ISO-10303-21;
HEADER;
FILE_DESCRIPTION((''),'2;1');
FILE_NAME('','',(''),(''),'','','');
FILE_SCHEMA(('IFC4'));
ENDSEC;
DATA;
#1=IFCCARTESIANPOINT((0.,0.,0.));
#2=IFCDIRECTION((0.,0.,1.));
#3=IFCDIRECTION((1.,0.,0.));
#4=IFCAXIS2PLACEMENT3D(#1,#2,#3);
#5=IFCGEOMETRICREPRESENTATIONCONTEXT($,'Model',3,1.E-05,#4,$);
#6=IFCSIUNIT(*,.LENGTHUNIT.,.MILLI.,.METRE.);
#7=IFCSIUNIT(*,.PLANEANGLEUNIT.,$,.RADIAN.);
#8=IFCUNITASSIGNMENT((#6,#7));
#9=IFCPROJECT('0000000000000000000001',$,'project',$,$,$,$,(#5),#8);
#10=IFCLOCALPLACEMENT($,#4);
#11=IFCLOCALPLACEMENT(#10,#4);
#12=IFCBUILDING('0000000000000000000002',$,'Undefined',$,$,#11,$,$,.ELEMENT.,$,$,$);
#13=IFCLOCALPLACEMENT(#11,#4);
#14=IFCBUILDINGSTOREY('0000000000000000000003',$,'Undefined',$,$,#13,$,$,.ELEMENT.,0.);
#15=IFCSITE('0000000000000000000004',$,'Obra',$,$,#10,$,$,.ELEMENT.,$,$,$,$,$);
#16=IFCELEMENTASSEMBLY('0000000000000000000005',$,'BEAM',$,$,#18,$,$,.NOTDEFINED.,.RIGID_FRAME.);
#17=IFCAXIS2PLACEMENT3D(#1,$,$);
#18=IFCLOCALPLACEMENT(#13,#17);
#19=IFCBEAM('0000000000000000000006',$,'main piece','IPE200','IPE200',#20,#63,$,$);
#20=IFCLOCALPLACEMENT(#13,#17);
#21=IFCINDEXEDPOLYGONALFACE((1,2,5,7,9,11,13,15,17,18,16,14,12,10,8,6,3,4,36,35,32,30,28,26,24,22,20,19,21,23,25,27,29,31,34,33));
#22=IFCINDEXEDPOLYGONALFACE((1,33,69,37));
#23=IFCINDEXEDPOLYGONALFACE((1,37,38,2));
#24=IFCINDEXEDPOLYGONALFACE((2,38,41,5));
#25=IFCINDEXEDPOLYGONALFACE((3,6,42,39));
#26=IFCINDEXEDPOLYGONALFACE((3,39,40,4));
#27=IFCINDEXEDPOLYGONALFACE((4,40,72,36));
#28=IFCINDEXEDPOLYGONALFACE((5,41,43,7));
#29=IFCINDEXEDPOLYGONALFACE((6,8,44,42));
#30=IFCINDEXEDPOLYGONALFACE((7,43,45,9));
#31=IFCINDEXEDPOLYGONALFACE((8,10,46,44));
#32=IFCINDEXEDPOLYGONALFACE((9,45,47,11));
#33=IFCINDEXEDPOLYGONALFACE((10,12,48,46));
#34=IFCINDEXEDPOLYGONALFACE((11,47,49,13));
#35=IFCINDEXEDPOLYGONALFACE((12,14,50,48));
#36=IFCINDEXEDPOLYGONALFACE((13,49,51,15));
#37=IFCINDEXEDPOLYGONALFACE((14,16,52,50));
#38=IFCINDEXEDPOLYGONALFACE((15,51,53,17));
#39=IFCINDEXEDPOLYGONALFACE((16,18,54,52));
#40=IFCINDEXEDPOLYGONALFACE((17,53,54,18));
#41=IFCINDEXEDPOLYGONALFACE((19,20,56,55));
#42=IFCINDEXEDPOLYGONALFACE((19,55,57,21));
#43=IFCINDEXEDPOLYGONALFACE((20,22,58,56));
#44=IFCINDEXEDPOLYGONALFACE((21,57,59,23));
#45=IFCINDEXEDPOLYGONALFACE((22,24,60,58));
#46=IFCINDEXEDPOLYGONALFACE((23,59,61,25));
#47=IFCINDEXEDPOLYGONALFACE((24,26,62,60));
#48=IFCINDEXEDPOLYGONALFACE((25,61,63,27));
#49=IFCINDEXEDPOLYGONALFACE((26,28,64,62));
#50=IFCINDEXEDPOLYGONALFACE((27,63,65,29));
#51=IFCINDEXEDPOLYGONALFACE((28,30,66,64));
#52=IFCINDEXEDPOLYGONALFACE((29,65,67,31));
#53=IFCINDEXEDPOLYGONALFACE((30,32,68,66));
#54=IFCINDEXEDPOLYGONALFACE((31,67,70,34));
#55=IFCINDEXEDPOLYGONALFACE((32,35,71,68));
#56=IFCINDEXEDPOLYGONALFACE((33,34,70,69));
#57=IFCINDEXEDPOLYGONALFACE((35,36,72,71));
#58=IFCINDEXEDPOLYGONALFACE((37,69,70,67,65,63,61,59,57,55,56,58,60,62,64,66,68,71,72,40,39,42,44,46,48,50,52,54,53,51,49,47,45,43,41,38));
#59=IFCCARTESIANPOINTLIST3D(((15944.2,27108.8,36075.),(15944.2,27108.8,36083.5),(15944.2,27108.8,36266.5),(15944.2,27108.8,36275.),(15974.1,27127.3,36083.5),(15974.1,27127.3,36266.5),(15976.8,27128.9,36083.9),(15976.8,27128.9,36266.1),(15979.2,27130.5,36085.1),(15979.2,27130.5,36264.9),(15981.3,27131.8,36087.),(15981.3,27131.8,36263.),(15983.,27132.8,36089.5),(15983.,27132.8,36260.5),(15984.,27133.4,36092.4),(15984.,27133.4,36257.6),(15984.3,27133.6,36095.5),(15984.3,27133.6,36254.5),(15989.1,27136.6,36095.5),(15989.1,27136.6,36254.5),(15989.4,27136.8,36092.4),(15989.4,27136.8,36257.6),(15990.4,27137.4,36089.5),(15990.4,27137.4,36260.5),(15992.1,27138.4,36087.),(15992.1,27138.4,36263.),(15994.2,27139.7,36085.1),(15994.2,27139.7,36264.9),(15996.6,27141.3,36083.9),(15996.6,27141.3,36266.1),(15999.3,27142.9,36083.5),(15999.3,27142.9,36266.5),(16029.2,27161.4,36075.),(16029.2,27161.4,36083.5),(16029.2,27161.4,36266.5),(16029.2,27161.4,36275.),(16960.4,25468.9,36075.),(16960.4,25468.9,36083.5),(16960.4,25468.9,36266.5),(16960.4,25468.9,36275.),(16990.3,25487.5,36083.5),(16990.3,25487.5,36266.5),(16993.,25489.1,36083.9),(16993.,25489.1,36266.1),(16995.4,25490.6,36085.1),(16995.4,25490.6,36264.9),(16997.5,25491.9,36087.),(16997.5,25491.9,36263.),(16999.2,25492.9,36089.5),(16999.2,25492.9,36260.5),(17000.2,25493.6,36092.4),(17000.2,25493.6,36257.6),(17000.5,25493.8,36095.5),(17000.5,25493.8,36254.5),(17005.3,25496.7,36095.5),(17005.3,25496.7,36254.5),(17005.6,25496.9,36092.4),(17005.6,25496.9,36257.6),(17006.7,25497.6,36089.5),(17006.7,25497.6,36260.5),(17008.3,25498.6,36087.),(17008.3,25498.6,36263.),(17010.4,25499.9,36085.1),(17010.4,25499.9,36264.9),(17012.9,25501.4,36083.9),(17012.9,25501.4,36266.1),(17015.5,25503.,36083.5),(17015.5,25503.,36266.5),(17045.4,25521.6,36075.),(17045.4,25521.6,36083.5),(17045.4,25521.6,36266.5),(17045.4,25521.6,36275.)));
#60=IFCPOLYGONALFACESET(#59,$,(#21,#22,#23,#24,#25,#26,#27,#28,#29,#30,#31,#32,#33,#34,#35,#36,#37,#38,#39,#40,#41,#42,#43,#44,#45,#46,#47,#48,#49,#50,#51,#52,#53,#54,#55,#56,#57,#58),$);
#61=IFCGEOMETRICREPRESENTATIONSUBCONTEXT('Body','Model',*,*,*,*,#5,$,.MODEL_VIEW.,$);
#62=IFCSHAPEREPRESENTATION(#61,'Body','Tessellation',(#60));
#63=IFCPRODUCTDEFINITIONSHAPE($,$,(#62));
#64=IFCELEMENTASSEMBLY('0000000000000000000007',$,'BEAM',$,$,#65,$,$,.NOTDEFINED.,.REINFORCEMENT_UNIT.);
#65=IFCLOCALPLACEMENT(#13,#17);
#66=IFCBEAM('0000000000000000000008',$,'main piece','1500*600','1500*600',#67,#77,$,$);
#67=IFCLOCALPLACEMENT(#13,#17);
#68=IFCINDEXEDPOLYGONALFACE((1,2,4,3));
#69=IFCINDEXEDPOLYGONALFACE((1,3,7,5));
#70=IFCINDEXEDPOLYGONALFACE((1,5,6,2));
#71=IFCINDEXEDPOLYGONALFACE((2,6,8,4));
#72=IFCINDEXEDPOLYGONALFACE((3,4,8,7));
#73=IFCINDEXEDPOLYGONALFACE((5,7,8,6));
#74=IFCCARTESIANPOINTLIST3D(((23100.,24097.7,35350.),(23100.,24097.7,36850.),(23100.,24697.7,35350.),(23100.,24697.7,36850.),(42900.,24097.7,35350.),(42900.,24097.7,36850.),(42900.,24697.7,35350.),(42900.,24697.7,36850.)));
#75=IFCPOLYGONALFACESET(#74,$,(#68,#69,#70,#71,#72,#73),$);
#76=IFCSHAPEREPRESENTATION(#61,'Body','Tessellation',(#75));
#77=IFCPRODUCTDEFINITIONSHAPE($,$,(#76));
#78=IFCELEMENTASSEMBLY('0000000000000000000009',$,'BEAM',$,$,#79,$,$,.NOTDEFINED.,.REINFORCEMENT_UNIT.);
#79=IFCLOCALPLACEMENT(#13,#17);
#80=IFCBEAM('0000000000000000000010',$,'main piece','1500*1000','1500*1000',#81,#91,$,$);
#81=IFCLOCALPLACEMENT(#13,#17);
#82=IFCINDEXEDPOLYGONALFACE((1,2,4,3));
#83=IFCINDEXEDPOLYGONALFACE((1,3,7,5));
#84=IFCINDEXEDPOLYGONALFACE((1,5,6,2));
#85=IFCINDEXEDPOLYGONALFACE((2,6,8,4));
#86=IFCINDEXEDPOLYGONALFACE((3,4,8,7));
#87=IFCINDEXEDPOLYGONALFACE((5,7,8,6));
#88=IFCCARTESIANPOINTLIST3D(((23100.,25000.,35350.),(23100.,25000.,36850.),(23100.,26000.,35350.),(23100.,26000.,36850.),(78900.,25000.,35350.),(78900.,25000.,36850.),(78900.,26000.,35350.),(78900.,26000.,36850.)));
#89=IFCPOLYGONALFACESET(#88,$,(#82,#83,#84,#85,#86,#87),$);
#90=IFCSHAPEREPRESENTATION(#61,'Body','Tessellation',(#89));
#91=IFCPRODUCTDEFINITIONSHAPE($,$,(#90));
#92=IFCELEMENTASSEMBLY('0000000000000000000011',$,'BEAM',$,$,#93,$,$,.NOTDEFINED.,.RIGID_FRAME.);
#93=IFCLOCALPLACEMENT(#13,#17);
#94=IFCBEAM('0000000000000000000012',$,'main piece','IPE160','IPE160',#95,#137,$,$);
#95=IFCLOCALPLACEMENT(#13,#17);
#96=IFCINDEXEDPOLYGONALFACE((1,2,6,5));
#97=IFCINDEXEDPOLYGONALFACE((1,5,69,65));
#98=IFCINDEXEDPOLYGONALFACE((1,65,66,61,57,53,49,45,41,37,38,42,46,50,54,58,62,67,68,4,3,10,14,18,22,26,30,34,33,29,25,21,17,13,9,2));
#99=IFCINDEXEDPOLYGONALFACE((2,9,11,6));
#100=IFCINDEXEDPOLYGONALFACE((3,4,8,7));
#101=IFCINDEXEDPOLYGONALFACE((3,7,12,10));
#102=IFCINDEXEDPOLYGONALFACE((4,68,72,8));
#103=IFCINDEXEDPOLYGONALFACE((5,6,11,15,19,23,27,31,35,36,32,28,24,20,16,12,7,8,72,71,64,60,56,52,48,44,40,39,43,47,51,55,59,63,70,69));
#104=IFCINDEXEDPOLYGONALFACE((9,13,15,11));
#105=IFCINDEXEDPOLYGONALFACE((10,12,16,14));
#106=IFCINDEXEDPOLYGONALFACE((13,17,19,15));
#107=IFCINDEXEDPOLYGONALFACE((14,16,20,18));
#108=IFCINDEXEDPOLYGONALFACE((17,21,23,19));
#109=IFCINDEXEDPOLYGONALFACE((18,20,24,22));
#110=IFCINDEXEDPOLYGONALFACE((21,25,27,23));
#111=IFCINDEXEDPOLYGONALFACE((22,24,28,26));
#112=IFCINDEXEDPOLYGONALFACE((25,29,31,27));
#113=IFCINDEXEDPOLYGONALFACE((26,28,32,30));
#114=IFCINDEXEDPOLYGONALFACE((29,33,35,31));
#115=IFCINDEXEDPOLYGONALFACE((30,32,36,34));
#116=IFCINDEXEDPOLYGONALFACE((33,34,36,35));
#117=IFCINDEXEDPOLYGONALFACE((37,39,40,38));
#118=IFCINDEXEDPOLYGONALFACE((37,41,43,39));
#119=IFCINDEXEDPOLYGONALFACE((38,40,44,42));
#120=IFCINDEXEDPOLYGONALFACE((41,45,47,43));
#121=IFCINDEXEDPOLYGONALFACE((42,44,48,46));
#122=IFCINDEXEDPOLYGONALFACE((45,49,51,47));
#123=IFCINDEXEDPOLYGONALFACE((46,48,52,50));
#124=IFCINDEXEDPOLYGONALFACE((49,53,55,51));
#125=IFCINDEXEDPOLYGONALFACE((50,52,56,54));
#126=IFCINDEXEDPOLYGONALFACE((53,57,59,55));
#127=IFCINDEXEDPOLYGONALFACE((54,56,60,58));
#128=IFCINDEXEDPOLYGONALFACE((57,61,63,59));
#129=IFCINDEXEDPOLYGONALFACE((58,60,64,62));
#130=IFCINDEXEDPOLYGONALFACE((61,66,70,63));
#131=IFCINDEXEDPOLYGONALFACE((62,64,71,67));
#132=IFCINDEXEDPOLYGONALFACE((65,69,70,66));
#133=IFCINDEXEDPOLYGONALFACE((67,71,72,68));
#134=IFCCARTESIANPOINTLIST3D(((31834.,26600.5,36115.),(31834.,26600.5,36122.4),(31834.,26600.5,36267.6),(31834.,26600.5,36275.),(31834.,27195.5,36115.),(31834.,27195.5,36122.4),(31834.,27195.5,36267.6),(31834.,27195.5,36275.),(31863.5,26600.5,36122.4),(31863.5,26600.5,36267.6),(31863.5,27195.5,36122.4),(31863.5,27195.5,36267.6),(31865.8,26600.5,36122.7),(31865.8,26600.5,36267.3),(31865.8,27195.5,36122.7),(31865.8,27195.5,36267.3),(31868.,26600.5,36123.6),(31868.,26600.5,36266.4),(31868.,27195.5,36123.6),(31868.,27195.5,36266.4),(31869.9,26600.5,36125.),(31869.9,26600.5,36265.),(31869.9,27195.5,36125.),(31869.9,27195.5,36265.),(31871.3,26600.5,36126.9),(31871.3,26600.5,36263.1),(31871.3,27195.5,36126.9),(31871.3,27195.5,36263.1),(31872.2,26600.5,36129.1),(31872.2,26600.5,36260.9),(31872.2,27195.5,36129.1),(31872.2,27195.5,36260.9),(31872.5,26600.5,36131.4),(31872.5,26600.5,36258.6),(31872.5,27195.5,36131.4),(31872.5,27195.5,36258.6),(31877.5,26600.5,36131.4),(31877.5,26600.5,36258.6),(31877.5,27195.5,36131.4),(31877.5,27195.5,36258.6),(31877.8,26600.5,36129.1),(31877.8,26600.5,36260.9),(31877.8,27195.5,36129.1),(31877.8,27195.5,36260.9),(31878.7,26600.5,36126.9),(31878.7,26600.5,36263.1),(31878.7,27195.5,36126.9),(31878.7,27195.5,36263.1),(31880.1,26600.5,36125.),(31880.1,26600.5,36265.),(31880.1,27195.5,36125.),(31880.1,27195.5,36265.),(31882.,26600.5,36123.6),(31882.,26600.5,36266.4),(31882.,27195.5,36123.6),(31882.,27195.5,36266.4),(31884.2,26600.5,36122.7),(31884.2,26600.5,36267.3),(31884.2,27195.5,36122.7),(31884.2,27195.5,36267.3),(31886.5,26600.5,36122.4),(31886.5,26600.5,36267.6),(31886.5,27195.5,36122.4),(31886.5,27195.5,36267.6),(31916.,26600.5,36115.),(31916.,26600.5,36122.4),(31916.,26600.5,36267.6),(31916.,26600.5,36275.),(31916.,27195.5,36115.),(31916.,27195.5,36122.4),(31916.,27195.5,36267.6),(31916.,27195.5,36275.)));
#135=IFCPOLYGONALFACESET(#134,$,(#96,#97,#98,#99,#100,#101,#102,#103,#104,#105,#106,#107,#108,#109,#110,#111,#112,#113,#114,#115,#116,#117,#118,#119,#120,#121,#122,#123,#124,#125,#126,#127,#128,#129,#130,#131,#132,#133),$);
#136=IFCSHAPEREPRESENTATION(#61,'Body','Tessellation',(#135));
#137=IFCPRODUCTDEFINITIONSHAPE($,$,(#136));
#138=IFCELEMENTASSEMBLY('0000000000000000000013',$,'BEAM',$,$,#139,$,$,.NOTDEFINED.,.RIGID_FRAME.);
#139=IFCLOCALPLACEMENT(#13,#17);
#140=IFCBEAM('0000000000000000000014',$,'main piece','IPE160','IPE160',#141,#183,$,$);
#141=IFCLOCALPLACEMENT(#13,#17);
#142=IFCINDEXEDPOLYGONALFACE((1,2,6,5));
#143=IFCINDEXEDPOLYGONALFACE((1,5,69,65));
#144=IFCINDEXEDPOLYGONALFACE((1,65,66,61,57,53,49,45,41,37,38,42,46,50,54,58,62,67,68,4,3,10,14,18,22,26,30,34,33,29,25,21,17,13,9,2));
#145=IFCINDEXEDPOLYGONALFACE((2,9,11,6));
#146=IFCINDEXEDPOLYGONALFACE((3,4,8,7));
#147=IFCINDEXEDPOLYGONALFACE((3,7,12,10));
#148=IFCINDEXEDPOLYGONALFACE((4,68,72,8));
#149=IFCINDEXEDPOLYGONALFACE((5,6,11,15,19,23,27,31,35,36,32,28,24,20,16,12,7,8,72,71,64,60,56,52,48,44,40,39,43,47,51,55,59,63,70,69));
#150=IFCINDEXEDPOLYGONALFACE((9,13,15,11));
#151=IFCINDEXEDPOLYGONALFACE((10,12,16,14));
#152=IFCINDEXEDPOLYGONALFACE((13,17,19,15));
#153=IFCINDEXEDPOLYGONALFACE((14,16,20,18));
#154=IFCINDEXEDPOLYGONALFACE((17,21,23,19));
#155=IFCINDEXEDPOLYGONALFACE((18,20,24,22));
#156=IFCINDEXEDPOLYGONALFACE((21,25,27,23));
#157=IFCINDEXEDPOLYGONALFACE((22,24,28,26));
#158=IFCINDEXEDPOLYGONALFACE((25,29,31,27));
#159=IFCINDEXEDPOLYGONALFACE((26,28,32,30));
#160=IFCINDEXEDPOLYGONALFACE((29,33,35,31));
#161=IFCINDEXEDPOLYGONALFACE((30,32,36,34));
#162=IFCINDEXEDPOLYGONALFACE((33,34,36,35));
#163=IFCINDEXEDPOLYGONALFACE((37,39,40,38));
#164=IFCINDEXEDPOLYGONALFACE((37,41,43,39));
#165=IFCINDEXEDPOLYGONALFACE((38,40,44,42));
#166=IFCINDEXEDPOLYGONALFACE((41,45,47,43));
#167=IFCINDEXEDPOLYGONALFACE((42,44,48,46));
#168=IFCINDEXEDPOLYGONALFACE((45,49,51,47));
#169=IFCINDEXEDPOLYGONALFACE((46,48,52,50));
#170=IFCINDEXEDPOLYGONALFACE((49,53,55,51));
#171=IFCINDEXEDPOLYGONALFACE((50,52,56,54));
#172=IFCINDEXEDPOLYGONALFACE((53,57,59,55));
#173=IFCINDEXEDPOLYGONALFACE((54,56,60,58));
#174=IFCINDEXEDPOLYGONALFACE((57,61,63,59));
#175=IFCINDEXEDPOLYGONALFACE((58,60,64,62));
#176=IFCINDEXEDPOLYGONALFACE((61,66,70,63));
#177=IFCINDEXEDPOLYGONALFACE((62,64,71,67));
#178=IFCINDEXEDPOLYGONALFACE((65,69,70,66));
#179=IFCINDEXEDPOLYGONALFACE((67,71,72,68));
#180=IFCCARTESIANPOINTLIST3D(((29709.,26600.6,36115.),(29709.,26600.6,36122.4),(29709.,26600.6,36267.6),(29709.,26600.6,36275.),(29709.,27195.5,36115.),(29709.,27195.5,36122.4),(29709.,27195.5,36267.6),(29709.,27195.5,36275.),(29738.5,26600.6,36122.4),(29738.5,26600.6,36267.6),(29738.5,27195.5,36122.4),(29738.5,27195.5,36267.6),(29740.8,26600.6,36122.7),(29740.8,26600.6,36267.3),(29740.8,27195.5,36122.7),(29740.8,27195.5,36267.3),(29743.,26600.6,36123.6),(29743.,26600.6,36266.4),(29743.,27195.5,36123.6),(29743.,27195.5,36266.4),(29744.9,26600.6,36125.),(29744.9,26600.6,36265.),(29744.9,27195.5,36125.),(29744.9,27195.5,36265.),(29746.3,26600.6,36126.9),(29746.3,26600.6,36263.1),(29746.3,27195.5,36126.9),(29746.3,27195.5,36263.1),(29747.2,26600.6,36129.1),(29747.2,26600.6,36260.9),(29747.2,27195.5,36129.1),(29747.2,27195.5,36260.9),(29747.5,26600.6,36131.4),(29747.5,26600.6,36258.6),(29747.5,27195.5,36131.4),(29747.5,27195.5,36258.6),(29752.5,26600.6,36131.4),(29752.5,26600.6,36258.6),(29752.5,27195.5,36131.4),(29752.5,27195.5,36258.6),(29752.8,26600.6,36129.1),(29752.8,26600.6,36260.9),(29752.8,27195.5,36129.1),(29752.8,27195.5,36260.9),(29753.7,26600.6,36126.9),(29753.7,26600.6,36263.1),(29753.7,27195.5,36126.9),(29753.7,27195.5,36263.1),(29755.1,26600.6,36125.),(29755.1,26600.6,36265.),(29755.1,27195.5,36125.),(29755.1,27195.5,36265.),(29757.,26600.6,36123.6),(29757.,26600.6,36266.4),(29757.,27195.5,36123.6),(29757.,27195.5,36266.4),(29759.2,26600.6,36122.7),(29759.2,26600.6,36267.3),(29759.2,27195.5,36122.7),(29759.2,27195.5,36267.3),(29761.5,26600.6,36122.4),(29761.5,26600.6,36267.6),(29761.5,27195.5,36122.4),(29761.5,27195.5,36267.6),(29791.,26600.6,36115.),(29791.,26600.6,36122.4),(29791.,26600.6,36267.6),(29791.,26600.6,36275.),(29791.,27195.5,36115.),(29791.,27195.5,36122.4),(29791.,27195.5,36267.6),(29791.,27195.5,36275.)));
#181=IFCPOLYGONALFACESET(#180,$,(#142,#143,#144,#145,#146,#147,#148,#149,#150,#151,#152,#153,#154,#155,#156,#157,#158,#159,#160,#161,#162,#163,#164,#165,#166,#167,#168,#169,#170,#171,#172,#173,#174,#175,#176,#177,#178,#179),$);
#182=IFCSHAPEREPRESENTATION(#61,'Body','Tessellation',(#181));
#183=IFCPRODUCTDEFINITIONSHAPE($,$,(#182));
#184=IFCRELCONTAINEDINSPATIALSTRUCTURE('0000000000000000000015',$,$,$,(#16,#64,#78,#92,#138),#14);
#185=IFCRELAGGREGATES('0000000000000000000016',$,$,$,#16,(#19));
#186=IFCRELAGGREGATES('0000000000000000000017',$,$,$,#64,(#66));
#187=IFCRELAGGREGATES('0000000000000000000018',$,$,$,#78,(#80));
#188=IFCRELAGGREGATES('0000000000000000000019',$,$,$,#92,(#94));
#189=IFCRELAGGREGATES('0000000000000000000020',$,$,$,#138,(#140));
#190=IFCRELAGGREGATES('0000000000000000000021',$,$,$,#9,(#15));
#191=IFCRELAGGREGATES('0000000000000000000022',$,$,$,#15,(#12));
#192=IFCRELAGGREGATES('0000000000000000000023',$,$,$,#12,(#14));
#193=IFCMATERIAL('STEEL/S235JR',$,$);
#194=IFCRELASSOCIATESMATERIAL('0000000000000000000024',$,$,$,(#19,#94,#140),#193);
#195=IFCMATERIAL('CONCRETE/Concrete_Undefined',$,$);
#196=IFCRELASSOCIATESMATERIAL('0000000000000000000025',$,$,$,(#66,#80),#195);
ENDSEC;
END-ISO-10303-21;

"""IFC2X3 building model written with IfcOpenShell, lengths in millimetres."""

from ifc_helpers import new_model, si_unit, frame, origin_with_axes, origin_2d_with_axis, place, context, subcontext, project, spatial, rectangle, i_section, extrude, material, element, aggregate, save


model = new_model("IFC2X3")

# Units and contexts
model_context = context("Model", 3, precision=1e-05, world=origin_with_axes())
body_context = subcontext(model_context, "Body", "Model", "MODEL_VIEW")
ifc_project = project(units=[si_unit("LENGTHUNIT", "METRE", prefix="MILLI"), si_unit("PLANEANGLEUNIT", "RADIAN")], contexts=[model_context])

# Site, building, storey
site_placement = place(None, origin_with_axes())
site = spatial("IfcSite", under=ifc_project, at=site_placement, Name="Obra", CompositionType="ELEMENT")
building_placement = place(site_placement, origin_with_axes())
building = spatial("IfcBuilding", under=site, at=building_placement, Name="Undefined", CompositionType="ELEMENT")
storey_placement = place(building_placement, origin_with_axes())
storey = spatial("IfcBuildingStorey", under=building, at=storey_placement, Name="Undefined", CompositionType="ELEMENT", Elevation=0.0)

# Shared definitions
ifc_material_1 = material(Name="STEEL/S235JR")

# Element assemblies, beams
ifc_material_2 = material(Name="CONCRETE/Concrete_Undefined")
assembly_1_placement = place(storey_placement, origin_with_axes())
assembly_1 = element("IfcElementAssembly", 1, at=assembly_1_placement, inside=storey, Name="BEAM", AssemblyPlace="NOTDEFINED", PredefinedType="RIGID_FRAME")
beam_1_placement = place(assembly_1_placement, frame((17002.9, 25495.3, 36175.0), z_axis=(0.0, 0.0, 1.0), x_axis=(-0.526756, 0.850017, 0.0)))
beam_1 = element("IfcBeam", 2, at=beam_1_placement, material=ifc_material_1, Name="main piece", Description="IPE200", ObjectType="IPE200", context=body_context, shape_type="SweptSolid", body=[
    extrude(i_section(OverallWidth=100.0, OverallDepth=200.0, WebThickness=5.6, FlangeThickness=8.5, FilletRadius=12.0, at=origin_2d_with_axis()), frame((1929.2, 0.0, 0.0), z_axis=(-1.0, 0.0, 0.0), x_axis=(0.0, -1.0, 0.0)), (0.0, 0.0, 1.0), 1929.2),
])
aggregate(assembly_1, [beam_1])
assembly_2_placement = place(storey_placement, origin_with_axes())
assembly_2 = element("IfcElementAssembly", 3, at=assembly_2_placement, inside=storey, Name="BEAM", AssemblyPlace="NOTDEFINED", PredefinedType="REINFORCEMENT_UNIT")
beam_2_placement = place(assembly_2_placement, frame((23100.0, 24397.7, 36100.0), z_axis=(0.0, 0.0, 1.0), x_axis=(1.0, 0.0, 0.0)))
beam_2 = element("IfcBeam", 4, at=beam_2_placement, material=ifc_material_2, Name="main piece", Description="1500*600", ObjectType="1500*600", context=body_context, shape_type="SweptSolid", body=[
    extrude(rectangle(XDim=600.0, YDim=1500.0, at=origin_2d_with_axis()), frame((19800.0, 0.0, 0.0), z_axis=(-1.0, 0.0, 0.0), x_axis=(0.0, -1.0, 0.0)), (0.0, 0.0, 1.0), 19800.0),
])
aggregate(assembly_2, [beam_2])
assembly_3_placement = place(storey_placement, origin_with_axes())
assembly_3 = element("IfcElementAssembly", 5, at=assembly_3_placement, inside=storey, Name="BEAM", AssemblyPlace="NOTDEFINED", PredefinedType="REINFORCEMENT_UNIT")
beam_3_placement = place(assembly_3_placement, frame((23100.0, 25500.0, 36100.0), z_axis=(0.0, 0.0, 1.0), x_axis=(1.0, 0.0, 0.0)))
beam_3 = element("IfcBeam", 6, at=beam_3_placement, material=ifc_material_2, Name="main piece", Description="1500*1000", ObjectType="1500*1000", context=body_context, shape_type="SweptSolid", body=[
    extrude(rectangle(XDim=1000.0, YDim=1500.0, at=origin_2d_with_axis()), frame((55800.0, 0.0, 0.0), z_axis=(-1.0, 0.0, 0.0), x_axis=(0.0, -1.0, 0.0)), (0.0, 0.0, 1.0), 55800.0),
])
aggregate(assembly_3, [beam_3])
assembly_4_placement = place(storey_placement, origin_with_axes())
assembly_4 = element("IfcElementAssembly", 7, at=assembly_4_placement, inside=storey, Name="BEAM", AssemblyPlace="NOTDEFINED", PredefinedType="RIGID_FRAME")
beam_4_placement = place(assembly_4_placement, frame((31875.0, 26600.5, 36195.0), z_axis=(0.0, 0.0, 1.0), x_axis=(0.0, 1.0, 0.0)))
beam_4 = element("IfcBeam", 8, at=beam_4_placement, material=ifc_material_1, Name="main piece", Description="IPE160", ObjectType="IPE160", context=body_context, shape_type="SweptSolid", body=[
    extrude(i_section(OverallWidth=82.0, OverallDepth=160.0, WebThickness=5.0, FlangeThickness=7.4, FilletRadius=9.0, at=origin_2d_with_axis()), frame((595.0, 0.0, 0.0), z_axis=(-1.0, 0.0, 0.0), x_axis=(0.0, -1.0, 0.0)), (0.0, 0.0, 1.0), 595.0),
])
aggregate(assembly_4, [beam_4])
assembly_5_placement = place(storey_placement, origin_with_axes())
assembly_5 = element("IfcElementAssembly", 9, at=assembly_5_placement, inside=storey, Name="BEAM", AssemblyPlace="NOTDEFINED", PredefinedType="RIGID_FRAME")
beam_5_placement = place(assembly_5_placement, frame((29750.0, 26600.6, 36195.0), z_axis=(0.0, 0.0, 1.0), x_axis=(0.0, 1.0, 0.0)))
beam_5 = element("IfcBeam", 10, at=beam_5_placement, material=ifc_material_1, Name="main piece", Description="IPE160", ObjectType="IPE160", context=body_context, shape_type="SweptSolid", body=[
    extrude(i_section(OverallWidth=82.0, OverallDepth=160.0, WebThickness=5.0, FlangeThickness=7.4, FilletRadius=9.0, at=origin_2d_with_axis()), frame((594.9, 0.0, 0.0), z_axis=(-1.0, 0.0, 0.0), x_axis=(0.0, -1.0, 0.0)), (0.0, 0.0, 1.0), 594.9),
])
aggregate(assembly_5, [beam_5])

save(model, "model.ifc")
